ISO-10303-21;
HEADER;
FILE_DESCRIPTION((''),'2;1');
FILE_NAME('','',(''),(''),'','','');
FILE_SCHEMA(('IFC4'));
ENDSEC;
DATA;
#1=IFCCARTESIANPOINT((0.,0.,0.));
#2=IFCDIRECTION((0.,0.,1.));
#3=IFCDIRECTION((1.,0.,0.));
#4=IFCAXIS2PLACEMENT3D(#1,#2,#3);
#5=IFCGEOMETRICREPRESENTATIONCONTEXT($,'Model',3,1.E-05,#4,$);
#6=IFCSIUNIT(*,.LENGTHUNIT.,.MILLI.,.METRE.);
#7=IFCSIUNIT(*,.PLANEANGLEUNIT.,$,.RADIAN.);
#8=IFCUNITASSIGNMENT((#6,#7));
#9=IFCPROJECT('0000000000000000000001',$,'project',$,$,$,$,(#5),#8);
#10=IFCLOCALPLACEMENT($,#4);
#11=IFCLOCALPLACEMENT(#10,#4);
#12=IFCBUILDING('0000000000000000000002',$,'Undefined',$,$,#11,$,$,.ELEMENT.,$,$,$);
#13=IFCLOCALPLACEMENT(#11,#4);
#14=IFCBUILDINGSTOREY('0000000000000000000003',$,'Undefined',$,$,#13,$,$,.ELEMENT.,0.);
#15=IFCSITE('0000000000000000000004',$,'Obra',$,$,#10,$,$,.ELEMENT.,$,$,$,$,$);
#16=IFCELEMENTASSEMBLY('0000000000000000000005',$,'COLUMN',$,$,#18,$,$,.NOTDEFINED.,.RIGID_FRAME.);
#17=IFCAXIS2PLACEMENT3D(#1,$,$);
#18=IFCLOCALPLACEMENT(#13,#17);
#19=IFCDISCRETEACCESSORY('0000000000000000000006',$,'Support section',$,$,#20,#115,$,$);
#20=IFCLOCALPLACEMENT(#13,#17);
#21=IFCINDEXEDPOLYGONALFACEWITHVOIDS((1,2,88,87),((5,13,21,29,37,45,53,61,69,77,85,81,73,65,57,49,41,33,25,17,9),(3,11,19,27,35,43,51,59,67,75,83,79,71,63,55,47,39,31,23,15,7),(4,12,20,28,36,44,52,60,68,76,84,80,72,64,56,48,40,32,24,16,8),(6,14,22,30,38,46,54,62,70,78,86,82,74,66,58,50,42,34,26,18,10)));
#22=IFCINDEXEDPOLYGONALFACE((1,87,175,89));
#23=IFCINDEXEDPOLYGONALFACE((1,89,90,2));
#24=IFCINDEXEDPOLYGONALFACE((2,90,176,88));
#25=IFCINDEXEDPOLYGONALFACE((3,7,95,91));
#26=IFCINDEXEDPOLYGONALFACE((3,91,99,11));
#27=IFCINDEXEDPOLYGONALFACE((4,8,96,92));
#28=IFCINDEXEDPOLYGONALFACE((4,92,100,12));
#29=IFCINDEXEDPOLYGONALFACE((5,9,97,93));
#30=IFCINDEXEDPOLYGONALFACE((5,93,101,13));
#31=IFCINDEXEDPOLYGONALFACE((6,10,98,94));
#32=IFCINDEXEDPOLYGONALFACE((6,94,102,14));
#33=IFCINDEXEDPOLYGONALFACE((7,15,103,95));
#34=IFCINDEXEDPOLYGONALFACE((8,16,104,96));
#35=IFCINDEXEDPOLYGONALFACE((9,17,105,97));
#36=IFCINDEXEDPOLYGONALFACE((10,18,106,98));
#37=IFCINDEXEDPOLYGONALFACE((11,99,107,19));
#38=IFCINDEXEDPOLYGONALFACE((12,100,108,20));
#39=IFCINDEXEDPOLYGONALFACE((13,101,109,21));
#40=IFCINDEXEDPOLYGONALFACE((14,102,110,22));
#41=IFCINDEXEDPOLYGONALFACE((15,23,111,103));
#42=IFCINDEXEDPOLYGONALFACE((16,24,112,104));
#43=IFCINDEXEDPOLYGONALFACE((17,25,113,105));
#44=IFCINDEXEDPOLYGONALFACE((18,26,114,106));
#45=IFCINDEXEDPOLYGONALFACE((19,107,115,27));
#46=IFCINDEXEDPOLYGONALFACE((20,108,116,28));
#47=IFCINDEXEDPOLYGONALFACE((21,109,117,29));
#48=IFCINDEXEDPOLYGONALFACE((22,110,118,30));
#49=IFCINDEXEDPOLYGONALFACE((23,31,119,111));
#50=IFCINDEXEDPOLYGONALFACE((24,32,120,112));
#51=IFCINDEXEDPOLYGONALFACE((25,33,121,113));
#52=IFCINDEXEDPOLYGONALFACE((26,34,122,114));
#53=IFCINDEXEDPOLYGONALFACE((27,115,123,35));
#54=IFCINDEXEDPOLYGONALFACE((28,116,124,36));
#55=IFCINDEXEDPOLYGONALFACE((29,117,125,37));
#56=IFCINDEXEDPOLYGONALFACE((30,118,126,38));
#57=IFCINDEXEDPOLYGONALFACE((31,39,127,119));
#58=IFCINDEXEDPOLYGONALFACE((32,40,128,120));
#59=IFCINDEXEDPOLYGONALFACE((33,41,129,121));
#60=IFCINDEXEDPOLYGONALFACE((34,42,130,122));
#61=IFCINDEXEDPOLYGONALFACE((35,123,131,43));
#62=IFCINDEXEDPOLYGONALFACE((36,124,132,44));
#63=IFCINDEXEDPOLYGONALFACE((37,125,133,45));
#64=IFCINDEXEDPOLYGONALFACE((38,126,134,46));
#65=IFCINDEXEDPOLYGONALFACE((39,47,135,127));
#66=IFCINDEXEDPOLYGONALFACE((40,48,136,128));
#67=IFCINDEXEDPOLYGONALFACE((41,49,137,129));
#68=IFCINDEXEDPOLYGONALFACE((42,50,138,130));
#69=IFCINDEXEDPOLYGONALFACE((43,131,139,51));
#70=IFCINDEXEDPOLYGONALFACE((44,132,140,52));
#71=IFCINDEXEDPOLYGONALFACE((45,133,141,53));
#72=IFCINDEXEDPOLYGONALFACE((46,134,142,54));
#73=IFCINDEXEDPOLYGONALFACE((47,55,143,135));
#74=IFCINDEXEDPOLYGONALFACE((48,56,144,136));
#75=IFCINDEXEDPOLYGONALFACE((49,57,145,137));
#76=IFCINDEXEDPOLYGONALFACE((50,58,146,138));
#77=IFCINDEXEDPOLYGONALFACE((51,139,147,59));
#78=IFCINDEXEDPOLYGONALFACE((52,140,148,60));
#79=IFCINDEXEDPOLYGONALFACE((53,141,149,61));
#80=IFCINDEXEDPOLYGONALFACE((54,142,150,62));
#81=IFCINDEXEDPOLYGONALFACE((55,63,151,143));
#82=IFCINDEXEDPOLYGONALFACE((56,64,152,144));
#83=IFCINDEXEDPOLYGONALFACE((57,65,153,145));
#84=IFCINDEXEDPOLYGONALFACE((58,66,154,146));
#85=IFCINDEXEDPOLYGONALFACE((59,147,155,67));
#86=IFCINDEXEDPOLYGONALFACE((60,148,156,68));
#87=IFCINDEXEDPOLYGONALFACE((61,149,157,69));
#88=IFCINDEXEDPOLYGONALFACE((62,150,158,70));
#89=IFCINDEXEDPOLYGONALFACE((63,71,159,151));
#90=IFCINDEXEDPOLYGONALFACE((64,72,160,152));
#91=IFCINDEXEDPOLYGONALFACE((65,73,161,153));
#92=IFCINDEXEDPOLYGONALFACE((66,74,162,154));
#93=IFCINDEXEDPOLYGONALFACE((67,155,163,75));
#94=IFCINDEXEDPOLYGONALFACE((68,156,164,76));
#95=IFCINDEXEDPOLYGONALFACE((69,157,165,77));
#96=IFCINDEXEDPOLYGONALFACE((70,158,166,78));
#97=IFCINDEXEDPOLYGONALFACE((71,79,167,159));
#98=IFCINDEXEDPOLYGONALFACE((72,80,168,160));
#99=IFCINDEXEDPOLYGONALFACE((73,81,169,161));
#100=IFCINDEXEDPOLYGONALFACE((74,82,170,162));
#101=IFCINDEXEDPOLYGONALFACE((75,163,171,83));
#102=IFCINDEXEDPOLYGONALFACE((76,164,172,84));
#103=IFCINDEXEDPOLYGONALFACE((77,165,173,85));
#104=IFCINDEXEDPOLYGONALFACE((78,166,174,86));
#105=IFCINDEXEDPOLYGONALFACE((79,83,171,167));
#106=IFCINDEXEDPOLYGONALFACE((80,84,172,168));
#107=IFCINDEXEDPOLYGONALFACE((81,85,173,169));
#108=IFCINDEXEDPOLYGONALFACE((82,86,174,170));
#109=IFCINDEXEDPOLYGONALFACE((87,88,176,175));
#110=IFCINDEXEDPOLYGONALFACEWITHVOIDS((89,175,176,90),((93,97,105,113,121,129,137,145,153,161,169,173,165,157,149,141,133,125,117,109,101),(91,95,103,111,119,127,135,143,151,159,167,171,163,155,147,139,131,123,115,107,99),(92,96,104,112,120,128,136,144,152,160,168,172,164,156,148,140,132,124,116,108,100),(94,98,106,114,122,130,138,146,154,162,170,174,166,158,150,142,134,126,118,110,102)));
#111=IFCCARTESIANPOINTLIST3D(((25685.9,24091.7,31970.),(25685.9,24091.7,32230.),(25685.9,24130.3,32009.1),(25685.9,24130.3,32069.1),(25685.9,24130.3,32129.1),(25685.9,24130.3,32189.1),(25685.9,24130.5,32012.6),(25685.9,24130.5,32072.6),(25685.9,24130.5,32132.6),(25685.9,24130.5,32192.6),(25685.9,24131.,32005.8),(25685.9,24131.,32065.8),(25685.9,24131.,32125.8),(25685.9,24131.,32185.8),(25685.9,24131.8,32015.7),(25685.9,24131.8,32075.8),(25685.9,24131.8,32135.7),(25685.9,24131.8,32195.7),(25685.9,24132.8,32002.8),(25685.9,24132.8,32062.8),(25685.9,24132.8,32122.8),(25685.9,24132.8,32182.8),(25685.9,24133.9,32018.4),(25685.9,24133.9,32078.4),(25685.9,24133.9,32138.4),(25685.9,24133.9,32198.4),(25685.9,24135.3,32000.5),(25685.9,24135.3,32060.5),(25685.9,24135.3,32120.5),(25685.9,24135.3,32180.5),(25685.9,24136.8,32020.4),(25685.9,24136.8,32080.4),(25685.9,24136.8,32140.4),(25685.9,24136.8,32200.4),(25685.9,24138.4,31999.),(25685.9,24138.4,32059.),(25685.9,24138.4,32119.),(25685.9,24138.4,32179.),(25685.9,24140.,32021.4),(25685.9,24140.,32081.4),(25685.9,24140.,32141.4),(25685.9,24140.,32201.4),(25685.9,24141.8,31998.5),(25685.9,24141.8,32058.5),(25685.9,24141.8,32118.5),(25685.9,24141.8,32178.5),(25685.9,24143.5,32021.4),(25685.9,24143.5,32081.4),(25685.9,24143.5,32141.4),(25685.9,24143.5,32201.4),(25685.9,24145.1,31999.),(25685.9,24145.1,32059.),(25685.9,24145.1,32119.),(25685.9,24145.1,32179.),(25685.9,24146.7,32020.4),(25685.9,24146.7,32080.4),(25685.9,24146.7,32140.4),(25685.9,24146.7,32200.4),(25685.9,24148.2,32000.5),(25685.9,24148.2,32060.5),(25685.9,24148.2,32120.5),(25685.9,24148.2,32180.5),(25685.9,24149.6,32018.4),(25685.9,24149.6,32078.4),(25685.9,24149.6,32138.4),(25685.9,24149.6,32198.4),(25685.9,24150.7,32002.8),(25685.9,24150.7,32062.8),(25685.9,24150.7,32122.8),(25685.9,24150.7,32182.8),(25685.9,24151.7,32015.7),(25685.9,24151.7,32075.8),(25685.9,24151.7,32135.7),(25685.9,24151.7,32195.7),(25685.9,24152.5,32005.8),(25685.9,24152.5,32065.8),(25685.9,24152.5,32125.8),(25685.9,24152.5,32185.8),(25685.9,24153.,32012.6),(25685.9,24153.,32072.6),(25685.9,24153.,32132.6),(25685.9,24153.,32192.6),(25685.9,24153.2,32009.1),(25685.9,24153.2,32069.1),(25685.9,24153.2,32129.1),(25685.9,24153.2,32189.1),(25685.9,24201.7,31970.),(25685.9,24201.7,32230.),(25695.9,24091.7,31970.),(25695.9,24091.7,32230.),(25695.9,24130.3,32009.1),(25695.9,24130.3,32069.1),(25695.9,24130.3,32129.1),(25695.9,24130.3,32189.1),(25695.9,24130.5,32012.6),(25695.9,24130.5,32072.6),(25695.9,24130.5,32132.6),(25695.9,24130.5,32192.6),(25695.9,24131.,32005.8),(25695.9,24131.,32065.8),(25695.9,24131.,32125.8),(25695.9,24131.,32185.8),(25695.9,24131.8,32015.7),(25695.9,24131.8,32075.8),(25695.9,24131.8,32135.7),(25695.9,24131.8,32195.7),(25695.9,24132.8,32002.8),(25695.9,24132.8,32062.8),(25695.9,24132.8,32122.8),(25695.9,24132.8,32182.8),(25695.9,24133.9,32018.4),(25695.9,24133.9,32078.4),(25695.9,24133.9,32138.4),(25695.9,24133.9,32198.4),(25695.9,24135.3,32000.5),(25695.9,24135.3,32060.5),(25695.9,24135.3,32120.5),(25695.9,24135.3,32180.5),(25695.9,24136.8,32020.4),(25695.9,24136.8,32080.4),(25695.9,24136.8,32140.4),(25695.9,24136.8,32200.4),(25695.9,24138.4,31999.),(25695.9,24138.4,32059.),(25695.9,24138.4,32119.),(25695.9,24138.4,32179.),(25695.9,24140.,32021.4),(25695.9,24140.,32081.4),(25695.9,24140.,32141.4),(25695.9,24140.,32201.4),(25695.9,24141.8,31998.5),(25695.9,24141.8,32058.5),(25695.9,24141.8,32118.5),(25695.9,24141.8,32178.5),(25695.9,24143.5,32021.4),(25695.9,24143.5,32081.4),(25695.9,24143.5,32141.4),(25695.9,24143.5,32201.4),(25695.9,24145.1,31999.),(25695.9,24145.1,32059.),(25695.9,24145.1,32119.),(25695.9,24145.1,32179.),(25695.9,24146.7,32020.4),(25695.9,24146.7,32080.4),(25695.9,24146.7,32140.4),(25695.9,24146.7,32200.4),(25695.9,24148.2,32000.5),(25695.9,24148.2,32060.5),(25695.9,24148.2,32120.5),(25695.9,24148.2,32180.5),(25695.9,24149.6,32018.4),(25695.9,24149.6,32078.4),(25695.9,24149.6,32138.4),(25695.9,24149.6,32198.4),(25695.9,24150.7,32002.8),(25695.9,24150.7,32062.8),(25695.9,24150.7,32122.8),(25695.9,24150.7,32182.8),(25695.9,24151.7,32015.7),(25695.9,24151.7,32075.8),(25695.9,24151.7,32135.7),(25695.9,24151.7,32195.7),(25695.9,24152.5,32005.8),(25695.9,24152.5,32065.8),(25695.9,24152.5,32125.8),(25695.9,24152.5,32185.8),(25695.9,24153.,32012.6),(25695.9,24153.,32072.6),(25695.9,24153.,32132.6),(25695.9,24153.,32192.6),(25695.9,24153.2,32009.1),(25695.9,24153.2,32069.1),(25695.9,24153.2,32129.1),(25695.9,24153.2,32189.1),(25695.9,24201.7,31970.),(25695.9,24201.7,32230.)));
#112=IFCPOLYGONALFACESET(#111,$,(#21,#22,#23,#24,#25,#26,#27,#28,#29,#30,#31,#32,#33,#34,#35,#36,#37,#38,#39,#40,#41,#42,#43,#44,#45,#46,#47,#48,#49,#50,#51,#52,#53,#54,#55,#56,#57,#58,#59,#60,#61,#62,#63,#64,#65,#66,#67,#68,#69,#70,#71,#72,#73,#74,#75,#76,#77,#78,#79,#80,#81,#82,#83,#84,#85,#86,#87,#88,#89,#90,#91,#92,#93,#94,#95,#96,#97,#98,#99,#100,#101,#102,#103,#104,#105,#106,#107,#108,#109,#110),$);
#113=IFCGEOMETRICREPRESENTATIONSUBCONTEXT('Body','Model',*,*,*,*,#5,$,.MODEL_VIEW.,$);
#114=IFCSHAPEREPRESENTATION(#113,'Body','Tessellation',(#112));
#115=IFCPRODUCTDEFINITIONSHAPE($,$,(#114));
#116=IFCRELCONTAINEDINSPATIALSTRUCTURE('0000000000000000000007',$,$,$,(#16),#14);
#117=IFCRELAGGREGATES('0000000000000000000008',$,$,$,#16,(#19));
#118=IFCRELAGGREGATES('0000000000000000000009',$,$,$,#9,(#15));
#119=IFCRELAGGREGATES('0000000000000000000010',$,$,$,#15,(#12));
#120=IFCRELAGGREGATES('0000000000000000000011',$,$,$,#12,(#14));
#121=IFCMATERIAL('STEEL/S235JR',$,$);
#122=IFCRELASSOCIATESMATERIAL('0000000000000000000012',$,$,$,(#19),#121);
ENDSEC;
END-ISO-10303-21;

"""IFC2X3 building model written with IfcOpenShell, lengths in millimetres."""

from ifc_helpers import new_model, si_unit, frame, origin_with_axes, origin_2d_with_axis, place, context, subcontext, project, spatial, rectangle, circle, extrude, source, transform, mapped, material, element, aggregate, save


model = new_model("IFC2X3")

# Units and contexts
model_context = context("Model", 3, precision=1e-05, world=origin_with_axes())
body_context = subcontext(model_context, "Body", "Model", "MODEL_VIEW")
ifc_project = project(units=[si_unit("LENGTHUNIT", "METRE", prefix="MILLI"), si_unit("PLANEANGLEUNIT", "RADIAN")], contexts=[model_context])

# Site, building, storey
site_placement = place(None, origin_with_axes())
site = spatial("IfcSite", under=ifc_project, at=site_placement, Name="Obra", CompositionType="ELEMENT")
building_placement = place(site_placement, origin_with_axes())
building = spatial("IfcBuilding", under=site, at=building_placement, Name="Undefined", CompositionType="ELEMENT")
storey_placement = place(building_placement, origin_with_axes())
storey = spatial("IfcBuildingStorey", under=building, at=storey_placement, Name="Undefined", CompositionType="ELEMENT", Elevation=0.0)

# Shared definitions
ifc_material_1 = material(Name="STEEL/S235JR")

# Element assembly
assembly_1_placement = place(storey_placement, origin_with_axes())
assembly_1 = element("IfcElementAssembly", 1, at=assembly_1_placement, inside=storey, Name="COLUMN", AssemblyPlace="NOTDEFINED", PredefinedType="RIGID_FRAME")
shared_shape_1 = source(origin_with_axes(), body_context, "Body", "SweptSolid", [
    extrude(circle(Radius=11.5, at=origin_2d_with_axis()), frame((0.0, -14.4, 0.0), z_axis=(0.0, 1.0, 0.0), x_axis=(1.0, 0.0, 0.0)), (0.0, 0.0, 1.0), 10.2),
])

# Discrete accessory, opening
discrete_accessory_1_placement = place(assembly_1_placement, frame((25690.9, 24146.7, 31970.0), z_axis=(0.0, 0.0, 1.0), x_axis=(0.0, 1.0, 0.0)))
discrete_accessory_1 = element("IfcDiscreteAccessory", 2, at=discrete_accessory_1_placement, material=ifc_material_1, Name="Support section", context=body_context, shape_type="SweptSolid", body=[
    extrude(rectangle(XDim=10.0, YDim=110.0, at=origin_2d_with_axis()), frame((0.0, 0.0, 260.0), z_axis=(0.0, 0.0, -1.0), x_axis=(0.0, 1.0, 0.0)), (0.0, 0.0, 1.0), 260.0),
])
opening_1_placement = place(assembly_1_placement, frame((25700.2, 24191.8, 32300.0), z_axis=(0.0, -1.0, 0.0), x_axis=(0.0, 0.0, -1.0)))
element("IfcOpeningElement", 3, at=opening_1_placement, cuts=discrete_accessory_1, ObjectType="Opening", context=body_context, shape_type="MappedRepresentation", body=[
    mapped(shared_shape_1, transform((110.0, 0.0, 50.0))),
    mapped(shared_shape_1, transform((170.0, 0.0, 50.0))),
    mapped(shared_shape_1, transform((230.0, 0.0, 50.0))),
    mapped(shared_shape_1, transform((290.0, 0.0, 50.0))),
])

aggregate(assembly_1, [discrete_accessory_1])

save(model, "model.ifc")
